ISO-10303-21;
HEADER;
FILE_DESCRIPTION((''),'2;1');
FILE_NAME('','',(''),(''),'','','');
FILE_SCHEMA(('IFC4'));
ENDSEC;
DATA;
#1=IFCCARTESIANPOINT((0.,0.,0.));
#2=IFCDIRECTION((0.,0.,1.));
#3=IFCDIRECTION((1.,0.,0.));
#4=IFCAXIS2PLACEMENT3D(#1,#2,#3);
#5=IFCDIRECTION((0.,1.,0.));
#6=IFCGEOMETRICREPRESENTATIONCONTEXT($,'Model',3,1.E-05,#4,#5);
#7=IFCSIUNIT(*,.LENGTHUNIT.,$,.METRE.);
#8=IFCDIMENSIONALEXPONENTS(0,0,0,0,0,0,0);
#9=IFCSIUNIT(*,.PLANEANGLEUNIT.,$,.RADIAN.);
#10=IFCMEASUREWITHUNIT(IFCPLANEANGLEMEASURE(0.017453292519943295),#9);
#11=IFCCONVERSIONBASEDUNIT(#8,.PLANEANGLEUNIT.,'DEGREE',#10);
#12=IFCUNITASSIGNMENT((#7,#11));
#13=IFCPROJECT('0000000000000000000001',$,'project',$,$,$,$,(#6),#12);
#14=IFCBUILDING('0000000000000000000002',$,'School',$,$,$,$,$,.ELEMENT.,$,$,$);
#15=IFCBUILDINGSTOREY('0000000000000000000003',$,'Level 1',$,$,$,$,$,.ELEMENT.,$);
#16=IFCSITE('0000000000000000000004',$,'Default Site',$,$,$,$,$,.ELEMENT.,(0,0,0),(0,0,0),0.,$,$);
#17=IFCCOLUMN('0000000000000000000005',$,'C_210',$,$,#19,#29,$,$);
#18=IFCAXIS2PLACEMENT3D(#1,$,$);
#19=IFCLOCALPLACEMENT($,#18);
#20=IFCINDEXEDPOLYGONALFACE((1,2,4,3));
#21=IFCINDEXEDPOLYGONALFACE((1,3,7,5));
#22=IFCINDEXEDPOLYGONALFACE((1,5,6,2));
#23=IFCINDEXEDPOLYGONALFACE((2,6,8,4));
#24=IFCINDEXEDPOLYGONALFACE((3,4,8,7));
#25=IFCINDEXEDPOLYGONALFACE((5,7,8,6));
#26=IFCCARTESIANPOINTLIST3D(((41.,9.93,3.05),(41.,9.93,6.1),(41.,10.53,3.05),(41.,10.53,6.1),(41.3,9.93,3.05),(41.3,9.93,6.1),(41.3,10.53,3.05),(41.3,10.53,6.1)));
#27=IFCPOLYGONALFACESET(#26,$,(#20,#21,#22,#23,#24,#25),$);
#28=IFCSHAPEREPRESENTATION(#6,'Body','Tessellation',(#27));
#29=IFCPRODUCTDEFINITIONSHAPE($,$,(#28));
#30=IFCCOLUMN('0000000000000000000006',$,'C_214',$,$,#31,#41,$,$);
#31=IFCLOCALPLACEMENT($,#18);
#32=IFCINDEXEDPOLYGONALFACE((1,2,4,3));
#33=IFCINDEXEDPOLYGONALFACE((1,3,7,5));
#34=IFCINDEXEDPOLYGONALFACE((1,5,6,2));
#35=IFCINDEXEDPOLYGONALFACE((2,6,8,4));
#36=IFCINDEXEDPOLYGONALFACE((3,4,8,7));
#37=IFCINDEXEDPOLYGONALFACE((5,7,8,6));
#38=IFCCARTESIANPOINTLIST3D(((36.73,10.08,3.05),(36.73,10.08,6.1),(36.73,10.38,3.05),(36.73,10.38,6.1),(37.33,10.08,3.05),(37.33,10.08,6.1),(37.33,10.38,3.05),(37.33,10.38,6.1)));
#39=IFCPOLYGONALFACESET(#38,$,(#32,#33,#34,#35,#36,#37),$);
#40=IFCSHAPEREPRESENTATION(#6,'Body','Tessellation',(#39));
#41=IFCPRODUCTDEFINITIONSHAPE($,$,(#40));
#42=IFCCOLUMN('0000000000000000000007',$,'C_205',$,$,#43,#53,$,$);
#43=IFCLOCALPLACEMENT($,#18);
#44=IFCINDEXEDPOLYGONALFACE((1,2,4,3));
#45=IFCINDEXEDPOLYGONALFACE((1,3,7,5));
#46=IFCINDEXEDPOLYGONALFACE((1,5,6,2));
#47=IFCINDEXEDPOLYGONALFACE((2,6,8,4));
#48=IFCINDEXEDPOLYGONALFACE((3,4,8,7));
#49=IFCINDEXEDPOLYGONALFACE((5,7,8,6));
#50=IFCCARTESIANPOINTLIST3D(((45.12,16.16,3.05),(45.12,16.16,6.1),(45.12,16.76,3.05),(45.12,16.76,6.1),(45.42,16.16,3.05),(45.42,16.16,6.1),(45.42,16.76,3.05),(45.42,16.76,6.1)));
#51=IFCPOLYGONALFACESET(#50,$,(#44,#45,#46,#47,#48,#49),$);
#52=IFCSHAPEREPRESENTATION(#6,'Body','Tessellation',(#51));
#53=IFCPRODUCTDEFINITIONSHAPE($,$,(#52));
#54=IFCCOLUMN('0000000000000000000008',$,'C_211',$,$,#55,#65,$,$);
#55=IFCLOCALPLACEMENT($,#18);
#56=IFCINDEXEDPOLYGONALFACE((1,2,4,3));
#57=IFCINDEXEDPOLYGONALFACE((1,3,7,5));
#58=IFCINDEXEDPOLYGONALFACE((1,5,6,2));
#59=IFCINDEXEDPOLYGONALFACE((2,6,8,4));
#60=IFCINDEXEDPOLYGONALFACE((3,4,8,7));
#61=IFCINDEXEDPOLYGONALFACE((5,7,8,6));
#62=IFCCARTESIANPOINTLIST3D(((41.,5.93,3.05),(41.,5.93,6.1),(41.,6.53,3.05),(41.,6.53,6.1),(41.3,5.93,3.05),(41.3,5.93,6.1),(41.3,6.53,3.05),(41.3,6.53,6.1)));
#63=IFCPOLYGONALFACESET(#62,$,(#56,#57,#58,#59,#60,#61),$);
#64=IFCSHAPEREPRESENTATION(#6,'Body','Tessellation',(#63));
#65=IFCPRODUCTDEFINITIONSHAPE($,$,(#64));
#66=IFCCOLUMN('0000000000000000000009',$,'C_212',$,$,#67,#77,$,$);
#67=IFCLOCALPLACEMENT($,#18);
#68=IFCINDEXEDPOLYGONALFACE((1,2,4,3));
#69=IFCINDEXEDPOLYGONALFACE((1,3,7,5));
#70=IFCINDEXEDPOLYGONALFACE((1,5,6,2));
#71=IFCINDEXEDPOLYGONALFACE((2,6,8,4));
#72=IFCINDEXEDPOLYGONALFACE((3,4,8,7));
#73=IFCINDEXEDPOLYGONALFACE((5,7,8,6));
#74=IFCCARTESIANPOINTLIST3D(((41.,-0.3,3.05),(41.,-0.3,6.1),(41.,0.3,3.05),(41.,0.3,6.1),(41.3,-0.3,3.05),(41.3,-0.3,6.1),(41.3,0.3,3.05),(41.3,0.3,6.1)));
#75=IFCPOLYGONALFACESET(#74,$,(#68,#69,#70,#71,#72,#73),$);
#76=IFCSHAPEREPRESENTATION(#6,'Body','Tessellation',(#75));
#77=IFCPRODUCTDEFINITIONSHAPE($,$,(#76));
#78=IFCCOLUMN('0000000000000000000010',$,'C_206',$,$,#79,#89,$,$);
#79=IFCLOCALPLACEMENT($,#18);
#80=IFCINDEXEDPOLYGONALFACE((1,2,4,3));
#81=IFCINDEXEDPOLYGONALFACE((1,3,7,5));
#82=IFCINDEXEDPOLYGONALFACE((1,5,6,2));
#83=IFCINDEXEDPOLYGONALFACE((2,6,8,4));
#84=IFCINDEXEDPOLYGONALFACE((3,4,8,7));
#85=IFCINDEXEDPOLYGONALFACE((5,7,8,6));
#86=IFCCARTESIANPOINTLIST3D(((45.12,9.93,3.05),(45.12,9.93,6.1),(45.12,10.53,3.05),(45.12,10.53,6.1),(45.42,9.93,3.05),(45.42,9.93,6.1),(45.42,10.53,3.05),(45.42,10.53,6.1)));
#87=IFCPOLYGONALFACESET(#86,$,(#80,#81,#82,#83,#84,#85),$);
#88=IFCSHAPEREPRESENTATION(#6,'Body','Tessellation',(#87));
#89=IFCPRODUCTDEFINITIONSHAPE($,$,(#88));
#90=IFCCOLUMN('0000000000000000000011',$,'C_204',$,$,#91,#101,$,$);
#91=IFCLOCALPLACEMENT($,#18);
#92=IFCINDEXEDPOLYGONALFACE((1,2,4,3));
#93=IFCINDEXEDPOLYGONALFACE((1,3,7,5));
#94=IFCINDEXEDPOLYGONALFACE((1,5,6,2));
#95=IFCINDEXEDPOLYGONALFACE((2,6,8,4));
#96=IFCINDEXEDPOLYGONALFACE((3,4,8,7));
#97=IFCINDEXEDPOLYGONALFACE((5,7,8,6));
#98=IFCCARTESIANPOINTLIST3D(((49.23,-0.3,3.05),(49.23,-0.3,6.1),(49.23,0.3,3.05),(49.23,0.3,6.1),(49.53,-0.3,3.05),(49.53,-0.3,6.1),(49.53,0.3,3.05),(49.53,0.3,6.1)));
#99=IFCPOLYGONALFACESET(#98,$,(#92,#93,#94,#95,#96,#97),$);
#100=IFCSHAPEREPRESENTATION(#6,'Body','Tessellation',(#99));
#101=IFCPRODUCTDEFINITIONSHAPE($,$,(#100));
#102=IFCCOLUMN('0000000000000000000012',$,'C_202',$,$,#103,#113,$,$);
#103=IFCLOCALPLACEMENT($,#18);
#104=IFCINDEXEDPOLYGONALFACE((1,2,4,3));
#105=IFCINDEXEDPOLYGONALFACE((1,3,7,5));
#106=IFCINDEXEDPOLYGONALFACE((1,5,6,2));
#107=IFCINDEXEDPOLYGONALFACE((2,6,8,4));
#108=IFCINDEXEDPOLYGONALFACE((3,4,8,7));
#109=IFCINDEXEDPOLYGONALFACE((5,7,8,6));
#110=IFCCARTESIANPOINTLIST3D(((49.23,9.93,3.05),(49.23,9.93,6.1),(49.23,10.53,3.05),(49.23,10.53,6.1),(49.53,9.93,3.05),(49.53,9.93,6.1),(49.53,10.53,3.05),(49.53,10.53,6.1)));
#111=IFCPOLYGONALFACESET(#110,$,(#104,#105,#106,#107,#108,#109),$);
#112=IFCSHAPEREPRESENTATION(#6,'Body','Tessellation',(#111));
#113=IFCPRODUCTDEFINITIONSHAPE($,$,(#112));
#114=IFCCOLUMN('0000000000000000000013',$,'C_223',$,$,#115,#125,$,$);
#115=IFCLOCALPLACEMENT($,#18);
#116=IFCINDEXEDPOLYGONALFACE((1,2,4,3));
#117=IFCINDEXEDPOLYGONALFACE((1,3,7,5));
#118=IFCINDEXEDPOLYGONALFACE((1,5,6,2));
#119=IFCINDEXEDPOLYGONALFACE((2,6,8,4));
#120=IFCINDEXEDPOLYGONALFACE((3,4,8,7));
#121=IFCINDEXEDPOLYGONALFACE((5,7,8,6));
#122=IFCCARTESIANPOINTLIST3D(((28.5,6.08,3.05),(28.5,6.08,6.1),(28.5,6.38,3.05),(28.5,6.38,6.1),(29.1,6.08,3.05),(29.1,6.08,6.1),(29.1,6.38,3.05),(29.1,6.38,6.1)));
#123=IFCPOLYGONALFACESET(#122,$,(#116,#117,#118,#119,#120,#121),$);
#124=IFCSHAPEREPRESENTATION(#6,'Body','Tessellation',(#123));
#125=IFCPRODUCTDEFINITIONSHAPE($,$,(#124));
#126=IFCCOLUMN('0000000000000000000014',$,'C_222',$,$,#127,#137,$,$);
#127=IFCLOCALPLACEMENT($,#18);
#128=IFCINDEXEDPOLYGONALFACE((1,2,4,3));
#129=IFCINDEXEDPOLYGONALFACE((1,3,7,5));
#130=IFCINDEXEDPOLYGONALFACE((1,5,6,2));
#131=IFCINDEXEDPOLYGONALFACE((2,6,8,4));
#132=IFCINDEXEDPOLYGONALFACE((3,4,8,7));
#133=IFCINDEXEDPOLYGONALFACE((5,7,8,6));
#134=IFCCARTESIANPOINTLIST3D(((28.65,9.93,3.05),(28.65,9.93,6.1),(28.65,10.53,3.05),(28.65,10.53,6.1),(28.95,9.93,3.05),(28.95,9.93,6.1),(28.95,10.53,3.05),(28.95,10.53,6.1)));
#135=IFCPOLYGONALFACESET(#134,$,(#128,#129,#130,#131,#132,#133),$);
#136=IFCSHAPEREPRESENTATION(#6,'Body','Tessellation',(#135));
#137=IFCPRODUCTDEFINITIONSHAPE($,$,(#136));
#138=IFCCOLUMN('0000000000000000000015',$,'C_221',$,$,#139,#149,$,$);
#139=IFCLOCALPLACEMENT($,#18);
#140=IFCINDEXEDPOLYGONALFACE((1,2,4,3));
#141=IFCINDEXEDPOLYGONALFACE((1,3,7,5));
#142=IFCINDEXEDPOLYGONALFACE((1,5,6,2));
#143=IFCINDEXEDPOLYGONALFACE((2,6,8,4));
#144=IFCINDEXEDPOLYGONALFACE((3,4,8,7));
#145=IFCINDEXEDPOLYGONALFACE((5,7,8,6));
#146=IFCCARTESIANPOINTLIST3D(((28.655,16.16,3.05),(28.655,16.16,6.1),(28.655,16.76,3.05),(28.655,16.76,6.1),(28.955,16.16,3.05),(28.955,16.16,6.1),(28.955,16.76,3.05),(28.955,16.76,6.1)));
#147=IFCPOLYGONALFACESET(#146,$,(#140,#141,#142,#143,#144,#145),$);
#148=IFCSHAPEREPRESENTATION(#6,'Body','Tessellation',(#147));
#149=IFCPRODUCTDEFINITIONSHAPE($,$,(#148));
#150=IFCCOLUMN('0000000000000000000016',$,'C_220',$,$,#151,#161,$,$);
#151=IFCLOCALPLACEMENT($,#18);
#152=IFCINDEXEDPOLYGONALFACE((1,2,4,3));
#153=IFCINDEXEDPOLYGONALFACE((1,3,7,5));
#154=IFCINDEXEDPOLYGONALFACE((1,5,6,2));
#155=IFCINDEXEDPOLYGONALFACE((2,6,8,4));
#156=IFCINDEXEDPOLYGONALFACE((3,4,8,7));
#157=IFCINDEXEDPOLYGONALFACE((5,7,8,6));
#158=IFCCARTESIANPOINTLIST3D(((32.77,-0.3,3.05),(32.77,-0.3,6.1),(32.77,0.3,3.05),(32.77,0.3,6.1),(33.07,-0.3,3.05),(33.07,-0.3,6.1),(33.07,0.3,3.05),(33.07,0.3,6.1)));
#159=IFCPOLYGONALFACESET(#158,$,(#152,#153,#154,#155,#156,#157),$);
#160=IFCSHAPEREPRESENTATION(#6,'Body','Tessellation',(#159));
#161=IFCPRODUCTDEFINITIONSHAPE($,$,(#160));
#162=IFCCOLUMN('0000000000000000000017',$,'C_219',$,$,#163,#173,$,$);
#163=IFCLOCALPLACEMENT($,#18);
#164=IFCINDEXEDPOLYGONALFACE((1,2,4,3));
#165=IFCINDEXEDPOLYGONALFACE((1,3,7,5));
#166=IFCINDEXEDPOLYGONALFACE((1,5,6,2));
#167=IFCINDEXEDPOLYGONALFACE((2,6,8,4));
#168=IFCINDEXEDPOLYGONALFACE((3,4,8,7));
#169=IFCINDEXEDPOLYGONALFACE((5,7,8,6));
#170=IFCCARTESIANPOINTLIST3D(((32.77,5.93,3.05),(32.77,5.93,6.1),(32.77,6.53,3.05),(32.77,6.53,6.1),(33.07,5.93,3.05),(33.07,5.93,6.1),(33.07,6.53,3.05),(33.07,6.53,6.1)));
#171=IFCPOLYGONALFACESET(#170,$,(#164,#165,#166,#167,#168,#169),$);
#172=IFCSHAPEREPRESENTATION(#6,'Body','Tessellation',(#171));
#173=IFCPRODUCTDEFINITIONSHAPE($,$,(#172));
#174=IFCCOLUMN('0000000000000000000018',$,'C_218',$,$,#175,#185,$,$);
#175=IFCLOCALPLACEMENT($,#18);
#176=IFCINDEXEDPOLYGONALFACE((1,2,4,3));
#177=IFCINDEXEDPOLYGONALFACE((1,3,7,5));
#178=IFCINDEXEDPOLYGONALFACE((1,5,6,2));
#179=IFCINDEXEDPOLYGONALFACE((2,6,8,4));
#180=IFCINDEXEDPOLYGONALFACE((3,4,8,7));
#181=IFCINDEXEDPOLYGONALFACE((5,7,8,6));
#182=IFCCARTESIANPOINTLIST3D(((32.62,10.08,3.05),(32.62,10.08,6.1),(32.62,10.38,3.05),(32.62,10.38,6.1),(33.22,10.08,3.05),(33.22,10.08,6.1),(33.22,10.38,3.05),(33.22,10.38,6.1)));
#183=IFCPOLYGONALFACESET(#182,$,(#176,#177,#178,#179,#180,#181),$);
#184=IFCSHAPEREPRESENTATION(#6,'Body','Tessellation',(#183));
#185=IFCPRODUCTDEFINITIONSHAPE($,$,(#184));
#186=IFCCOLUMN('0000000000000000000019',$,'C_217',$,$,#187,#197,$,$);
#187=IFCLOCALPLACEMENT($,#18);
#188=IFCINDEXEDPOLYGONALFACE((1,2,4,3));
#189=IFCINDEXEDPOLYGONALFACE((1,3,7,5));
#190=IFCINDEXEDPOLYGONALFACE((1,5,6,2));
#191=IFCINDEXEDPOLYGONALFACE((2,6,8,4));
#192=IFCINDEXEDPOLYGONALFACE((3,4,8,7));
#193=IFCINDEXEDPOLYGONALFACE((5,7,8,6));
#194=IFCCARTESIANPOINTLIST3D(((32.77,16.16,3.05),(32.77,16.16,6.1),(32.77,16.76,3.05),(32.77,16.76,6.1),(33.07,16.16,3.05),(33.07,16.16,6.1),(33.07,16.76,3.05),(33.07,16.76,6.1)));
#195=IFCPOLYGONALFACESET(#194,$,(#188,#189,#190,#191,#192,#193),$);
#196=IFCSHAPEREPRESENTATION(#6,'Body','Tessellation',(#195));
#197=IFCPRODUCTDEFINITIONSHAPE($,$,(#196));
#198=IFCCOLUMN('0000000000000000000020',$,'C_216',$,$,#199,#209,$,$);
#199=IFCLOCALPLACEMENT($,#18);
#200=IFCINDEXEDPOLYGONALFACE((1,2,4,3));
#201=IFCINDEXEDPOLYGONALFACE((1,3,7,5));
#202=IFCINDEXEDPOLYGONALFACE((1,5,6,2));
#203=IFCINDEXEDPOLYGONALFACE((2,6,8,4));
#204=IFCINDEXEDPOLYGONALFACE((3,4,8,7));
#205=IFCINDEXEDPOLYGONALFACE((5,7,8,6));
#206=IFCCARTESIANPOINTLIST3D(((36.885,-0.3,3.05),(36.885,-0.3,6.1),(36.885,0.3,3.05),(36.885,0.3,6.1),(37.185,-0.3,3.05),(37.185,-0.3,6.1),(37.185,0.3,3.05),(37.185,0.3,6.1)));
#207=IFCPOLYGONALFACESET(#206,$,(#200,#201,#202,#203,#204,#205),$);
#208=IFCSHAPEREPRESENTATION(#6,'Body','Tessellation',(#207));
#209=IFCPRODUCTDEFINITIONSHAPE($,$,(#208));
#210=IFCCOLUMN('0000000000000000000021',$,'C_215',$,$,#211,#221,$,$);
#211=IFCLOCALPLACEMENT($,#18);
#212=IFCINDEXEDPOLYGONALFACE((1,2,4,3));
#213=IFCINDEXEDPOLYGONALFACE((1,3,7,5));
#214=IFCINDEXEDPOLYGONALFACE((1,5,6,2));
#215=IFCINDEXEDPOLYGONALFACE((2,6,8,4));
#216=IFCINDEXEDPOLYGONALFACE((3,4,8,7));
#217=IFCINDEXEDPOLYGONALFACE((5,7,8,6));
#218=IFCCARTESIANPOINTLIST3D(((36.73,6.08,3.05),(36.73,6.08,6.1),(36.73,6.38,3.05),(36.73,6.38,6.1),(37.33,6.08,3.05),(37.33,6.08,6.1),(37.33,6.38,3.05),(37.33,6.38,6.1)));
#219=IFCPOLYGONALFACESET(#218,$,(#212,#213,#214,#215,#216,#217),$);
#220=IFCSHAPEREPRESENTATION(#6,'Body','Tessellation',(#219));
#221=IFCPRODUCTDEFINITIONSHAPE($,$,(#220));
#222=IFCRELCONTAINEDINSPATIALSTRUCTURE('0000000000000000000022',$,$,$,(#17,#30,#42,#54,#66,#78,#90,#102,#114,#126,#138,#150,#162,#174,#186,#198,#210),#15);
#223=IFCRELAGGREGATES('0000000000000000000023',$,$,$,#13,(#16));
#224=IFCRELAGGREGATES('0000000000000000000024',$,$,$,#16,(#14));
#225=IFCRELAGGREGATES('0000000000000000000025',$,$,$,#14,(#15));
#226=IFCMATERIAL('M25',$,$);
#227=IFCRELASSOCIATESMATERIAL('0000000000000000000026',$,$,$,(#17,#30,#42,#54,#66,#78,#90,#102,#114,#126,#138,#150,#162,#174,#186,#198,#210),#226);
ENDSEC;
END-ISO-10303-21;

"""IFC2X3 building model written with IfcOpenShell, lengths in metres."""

from ifc_helpers import new_model, entity, si_unit, converted_unit, direction, frame, frame_2d, origin_with_axes, place, context, project, spatial, rectangle, extrude, material, element, save


model = new_model("IFC2X3")

# Units and contexts
model_context = context("Model", 3, precision=1e-05, world=origin_with_axes(), true_north=direction((0.0, 1.0, 0.0)))
ifc_project = project(units=[si_unit("LENGTHUNIT", "METRE"), converted_unit("PLANEANGLEUNIT", "DEGREE", entity("IfcPlaneAngleMeasure", 0.017453292519943295), si_unit("PLANEANGLEUNIT", "RADIAN"), dimensions=[0, 0, 0, 0, 0, 0, 0])], contexts=[model_context])

# Site, building, storey
site = spatial("IfcSite", under=ifc_project, Name="Default Site", CompositionType="ELEMENT", RefLatitude=(0, 0, 0), RefLongitude=(0, 0, 0), RefElevation=0.0)
building = spatial("IfcBuilding", under=site, Name="School", CompositionType="ELEMENT")
storey = spatial("IfcBuildingStorey", under=building, Name="Level 1", CompositionType="ELEMENT")

# Columns
ifc_material = material(Name="M25")
placement = place(None, origin_with_axes())
element("IfcColumn", 1, at=placement, inside=storey, material=ifc_material, Name="C_210", context=model_context, shape_type="SweptSolid", body=[
    extrude(rectangle(XDim=0.3, YDim=0.6, at=frame_2d((0.0, 0.0), x_axis=(1.0, 0.0, 0.0))), frame((41.15, 10.23, 3.05), z_axis=(0.0, 0.0, 1.0), x_axis=(1.0, 0.0, 0.0)), (0.0, 0.0, 1.0), 3.05),
])
element("IfcColumn", 2, at=placement, inside=storey, material=ifc_material, Name="C_214", context=model_context, shape_type="SweptSolid", body=[
    extrude(rectangle(XDim=0.6, YDim=0.3, at=frame_2d((0.0, 0.0), x_axis=(1.0, 0.0, 0.0))), frame((37.03, 10.23, 3.05), z_axis=(0.0, 0.0, 1.0), x_axis=(1.0, 0.0, 0.0)), (0.0, 0.0, 1.0), 3.05),
])
element("IfcColumn", 3, at=placement, inside=storey, material=ifc_material, Name="C_205", context=model_context, shape_type="SweptSolid", body=[
    extrude(rectangle(XDim=0.3, YDim=0.6, at=frame_2d((0.0, 0.0), x_axis=(1.0, 0.0, 0.0))), frame((45.27, 16.46, 3.05), z_axis=(0.0, 0.0, 1.0), x_axis=(1.0, 0.0, 0.0)), (0.0, 0.0, 1.0), 3.05),
])
element("IfcColumn", 4, at=placement, inside=storey, material=ifc_material, Name="C_211", context=model_context, shape_type="SweptSolid", body=[
    extrude(rectangle(XDim=0.3, YDim=0.6, at=frame_2d((0.0, 0.0), x_axis=(1.0, 0.0, 0.0))), frame((41.15, 6.23, 3.05), z_axis=(0.0, 0.0, 1.0), x_axis=(1.0, 0.0, 0.0)), (0.0, 0.0, 1.0), 3.05),
])
element("IfcColumn", 5, at=placement, inside=storey, material=ifc_material, Name="C_212", context=model_context, shape_type="SweptSolid", body=[
    extrude(rectangle(XDim=0.3, YDim=0.6, at=frame_2d((0.0, 0.0), x_axis=(1.0, 0.0, 0.0))), frame((41.15, 0.0, 3.05), z_axis=(0.0, 0.0, 1.0), x_axis=(1.0, 0.0, 0.0)), (0.0, 0.0, 1.0), 3.05),
])
element("IfcColumn", 6, at=placement, inside=storey, material=ifc_material, Name="C_206", context=model_context, shape_type="SweptSolid", body=[
    extrude(rectangle(XDim=0.3, YDim=0.6, at=frame_2d((0.0, 0.0), x_axis=(1.0, 0.0, 0.0))), frame((45.27, 10.23, 3.05), z_axis=(0.0, 0.0, 1.0), x_axis=(1.0, 0.0, 0.0)), (0.0, 0.0, 1.0), 3.05),
])
element("IfcColumn", 7, at=placement, inside=storey, material=ifc_material, Name="C_204", context=model_context, shape_type="SweptSolid", body=[
    extrude(rectangle(XDim=0.3, YDim=0.6, at=frame_2d((0.0, 0.0), x_axis=(1.0, 0.0, 0.0))), frame((49.38, 0.0, 3.05), z_axis=(0.0, 0.0, 1.0), x_axis=(1.0, 0.0, 0.0)), (0.0, 0.0, 1.0), 3.05),
])
element("IfcColumn", 8, at=placement, inside=storey, material=ifc_material, Name="C_202", context=model_context, shape_type="SweptSolid", body=[
    extrude(rectangle(XDim=0.3, YDim=0.6, at=frame_2d((0.0, 0.0), x_axis=(1.0, 0.0, 0.0))), frame((49.38, 10.23, 3.05), z_axis=(0.0, 0.0, 1.0), x_axis=(1.0, 0.0, 0.0)), (0.0, 0.0, 1.0), 3.05),
])
element("IfcColumn", 9, at=placement, inside=storey, material=ifc_material, Name="C_223", context=model_context, shape_type="SweptSolid", body=[
    extrude(rectangle(XDim=0.6, YDim=0.3, at=frame_2d((0.0, 0.0), x_axis=(1.0, 0.0, 0.0))), frame((28.8, 6.23, 3.05), z_axis=(0.0, 0.0, 1.0), x_axis=(1.0, 0.0, 0.0)), (0.0, 0.0, 1.0), 3.05),
])
element("IfcColumn", 10, at=placement, inside=storey, material=ifc_material, Name="C_222", context=model_context, shape_type="SweptSolid", body=[
    extrude(rectangle(XDim=0.3, YDim=0.6, at=frame_2d((0.0, 0.0), x_axis=(1.0, 0.0, 0.0))), frame((28.8, 10.23, 3.05), z_axis=(0.0, 0.0, 1.0), x_axis=(1.0, 0.0, 0.0)), (0.0, 0.0, 1.0), 3.05),
])
element("IfcColumn", 11, at=placement, inside=storey, material=ifc_material, Name="C_221", context=model_context, shape_type="SweptSolid", body=[
    extrude(rectangle(XDim=0.3, YDim=0.6, at=frame_2d((0.0, 0.0), x_axis=(1.0, 0.0, 0.0))), frame((28.805, 16.46, 3.05), z_axis=(0.0, 0.0, 1.0), x_axis=(1.0, 0.0, 0.0)), (0.0, 0.0, 1.0), 3.05),
])
element("IfcColumn", 12, at=placement, inside=storey, material=ifc_material, Name="C_220", context=model_context, shape_type="SweptSolid", body=[
    extrude(rectangle(XDim=0.3, YDim=0.6, at=frame_2d((0.0, 0.0), x_axis=(1.0, 0.0, 0.0))), frame((32.92, 0.0, 3.05), z_axis=(0.0, 0.0, 1.0), x_axis=(1.0, 0.0, 0.0)), (0.0, 0.0, 1.0), 3.05),
])
element("IfcColumn", 13, at=placement, inside=storey, material=ifc_material, Name="C_219", context=model_context, shape_type="SweptSolid", body=[
    extrude(rectangle(XDim=0.3, YDim=0.6, at=frame_2d((0.0, 0.0), x_axis=(1.0, 0.0, 0.0))), frame((32.92, 6.23, 3.05), z_axis=(0.0, 0.0, 1.0), x_axis=(1.0, 0.0, 0.0)), (0.0, 0.0, 1.0), 3.05),
])
element("IfcColumn", 14, at=placement, inside=storey, material=ifc_material, Name="C_218", context=model_context, shape_type="SweptSolid", body=[
    extrude(rectangle(XDim=0.6, YDim=0.3, at=frame_2d((0.0, 0.0), x_axis=(1.0, 0.0, 0.0))), frame((32.92, 10.23, 3.05), z_axis=(0.0, 0.0, 1.0), x_axis=(1.0, 0.0, 0.0)), (0.0, 0.0, 1.0), 3.05),
])
element("IfcColumn", 15, at=placement, inside=storey, material=ifc_material, Name="C_217", context=model_context, shape_type="SweptSolid", body=[
    extrude(rectangle(XDim=0.3, YDim=0.6, at=frame_2d((0.0, 0.0), x_axis=(1.0, 0.0, 0.0))), frame((32.92, 16.46, 3.05), z_axis=(0.0, 0.0, 1.0), x_axis=(1.0, 0.0, 0.0)), (0.0, 0.0, 1.0), 3.05),
])
element("IfcColumn", 16, at=placement, inside=storey, material=ifc_material, Name="C_216", context=model_context, shape_type="SweptSolid", body=[
    extrude(rectangle(XDim=0.3, YDim=0.6, at=frame_2d((0.0, 0.0), x_axis=(1.0, 0.0, 0.0))), frame((37.035, 0.0, 3.05), z_axis=(0.0, 0.0, 1.0), x_axis=(1.0, 0.0, 0.0)), (0.0, 0.0, 1.0), 3.05),
])
element("IfcColumn", 17, at=placement, inside=storey, material=ifc_material, Name="C_215", context=model_context, shape_type="SweptSolid", body=[
    extrude(rectangle(XDim=0.6, YDim=0.3, at=frame_2d((0.0, 0.0), x_axis=(1.0, 0.0, 0.0))), frame((37.03, 6.23, 3.05), z_axis=(0.0, 0.0, 1.0), x_axis=(1.0, 0.0, 0.0)), (0.0, 0.0, 1.0), 3.05),
])

save(model, "model.ifc")
